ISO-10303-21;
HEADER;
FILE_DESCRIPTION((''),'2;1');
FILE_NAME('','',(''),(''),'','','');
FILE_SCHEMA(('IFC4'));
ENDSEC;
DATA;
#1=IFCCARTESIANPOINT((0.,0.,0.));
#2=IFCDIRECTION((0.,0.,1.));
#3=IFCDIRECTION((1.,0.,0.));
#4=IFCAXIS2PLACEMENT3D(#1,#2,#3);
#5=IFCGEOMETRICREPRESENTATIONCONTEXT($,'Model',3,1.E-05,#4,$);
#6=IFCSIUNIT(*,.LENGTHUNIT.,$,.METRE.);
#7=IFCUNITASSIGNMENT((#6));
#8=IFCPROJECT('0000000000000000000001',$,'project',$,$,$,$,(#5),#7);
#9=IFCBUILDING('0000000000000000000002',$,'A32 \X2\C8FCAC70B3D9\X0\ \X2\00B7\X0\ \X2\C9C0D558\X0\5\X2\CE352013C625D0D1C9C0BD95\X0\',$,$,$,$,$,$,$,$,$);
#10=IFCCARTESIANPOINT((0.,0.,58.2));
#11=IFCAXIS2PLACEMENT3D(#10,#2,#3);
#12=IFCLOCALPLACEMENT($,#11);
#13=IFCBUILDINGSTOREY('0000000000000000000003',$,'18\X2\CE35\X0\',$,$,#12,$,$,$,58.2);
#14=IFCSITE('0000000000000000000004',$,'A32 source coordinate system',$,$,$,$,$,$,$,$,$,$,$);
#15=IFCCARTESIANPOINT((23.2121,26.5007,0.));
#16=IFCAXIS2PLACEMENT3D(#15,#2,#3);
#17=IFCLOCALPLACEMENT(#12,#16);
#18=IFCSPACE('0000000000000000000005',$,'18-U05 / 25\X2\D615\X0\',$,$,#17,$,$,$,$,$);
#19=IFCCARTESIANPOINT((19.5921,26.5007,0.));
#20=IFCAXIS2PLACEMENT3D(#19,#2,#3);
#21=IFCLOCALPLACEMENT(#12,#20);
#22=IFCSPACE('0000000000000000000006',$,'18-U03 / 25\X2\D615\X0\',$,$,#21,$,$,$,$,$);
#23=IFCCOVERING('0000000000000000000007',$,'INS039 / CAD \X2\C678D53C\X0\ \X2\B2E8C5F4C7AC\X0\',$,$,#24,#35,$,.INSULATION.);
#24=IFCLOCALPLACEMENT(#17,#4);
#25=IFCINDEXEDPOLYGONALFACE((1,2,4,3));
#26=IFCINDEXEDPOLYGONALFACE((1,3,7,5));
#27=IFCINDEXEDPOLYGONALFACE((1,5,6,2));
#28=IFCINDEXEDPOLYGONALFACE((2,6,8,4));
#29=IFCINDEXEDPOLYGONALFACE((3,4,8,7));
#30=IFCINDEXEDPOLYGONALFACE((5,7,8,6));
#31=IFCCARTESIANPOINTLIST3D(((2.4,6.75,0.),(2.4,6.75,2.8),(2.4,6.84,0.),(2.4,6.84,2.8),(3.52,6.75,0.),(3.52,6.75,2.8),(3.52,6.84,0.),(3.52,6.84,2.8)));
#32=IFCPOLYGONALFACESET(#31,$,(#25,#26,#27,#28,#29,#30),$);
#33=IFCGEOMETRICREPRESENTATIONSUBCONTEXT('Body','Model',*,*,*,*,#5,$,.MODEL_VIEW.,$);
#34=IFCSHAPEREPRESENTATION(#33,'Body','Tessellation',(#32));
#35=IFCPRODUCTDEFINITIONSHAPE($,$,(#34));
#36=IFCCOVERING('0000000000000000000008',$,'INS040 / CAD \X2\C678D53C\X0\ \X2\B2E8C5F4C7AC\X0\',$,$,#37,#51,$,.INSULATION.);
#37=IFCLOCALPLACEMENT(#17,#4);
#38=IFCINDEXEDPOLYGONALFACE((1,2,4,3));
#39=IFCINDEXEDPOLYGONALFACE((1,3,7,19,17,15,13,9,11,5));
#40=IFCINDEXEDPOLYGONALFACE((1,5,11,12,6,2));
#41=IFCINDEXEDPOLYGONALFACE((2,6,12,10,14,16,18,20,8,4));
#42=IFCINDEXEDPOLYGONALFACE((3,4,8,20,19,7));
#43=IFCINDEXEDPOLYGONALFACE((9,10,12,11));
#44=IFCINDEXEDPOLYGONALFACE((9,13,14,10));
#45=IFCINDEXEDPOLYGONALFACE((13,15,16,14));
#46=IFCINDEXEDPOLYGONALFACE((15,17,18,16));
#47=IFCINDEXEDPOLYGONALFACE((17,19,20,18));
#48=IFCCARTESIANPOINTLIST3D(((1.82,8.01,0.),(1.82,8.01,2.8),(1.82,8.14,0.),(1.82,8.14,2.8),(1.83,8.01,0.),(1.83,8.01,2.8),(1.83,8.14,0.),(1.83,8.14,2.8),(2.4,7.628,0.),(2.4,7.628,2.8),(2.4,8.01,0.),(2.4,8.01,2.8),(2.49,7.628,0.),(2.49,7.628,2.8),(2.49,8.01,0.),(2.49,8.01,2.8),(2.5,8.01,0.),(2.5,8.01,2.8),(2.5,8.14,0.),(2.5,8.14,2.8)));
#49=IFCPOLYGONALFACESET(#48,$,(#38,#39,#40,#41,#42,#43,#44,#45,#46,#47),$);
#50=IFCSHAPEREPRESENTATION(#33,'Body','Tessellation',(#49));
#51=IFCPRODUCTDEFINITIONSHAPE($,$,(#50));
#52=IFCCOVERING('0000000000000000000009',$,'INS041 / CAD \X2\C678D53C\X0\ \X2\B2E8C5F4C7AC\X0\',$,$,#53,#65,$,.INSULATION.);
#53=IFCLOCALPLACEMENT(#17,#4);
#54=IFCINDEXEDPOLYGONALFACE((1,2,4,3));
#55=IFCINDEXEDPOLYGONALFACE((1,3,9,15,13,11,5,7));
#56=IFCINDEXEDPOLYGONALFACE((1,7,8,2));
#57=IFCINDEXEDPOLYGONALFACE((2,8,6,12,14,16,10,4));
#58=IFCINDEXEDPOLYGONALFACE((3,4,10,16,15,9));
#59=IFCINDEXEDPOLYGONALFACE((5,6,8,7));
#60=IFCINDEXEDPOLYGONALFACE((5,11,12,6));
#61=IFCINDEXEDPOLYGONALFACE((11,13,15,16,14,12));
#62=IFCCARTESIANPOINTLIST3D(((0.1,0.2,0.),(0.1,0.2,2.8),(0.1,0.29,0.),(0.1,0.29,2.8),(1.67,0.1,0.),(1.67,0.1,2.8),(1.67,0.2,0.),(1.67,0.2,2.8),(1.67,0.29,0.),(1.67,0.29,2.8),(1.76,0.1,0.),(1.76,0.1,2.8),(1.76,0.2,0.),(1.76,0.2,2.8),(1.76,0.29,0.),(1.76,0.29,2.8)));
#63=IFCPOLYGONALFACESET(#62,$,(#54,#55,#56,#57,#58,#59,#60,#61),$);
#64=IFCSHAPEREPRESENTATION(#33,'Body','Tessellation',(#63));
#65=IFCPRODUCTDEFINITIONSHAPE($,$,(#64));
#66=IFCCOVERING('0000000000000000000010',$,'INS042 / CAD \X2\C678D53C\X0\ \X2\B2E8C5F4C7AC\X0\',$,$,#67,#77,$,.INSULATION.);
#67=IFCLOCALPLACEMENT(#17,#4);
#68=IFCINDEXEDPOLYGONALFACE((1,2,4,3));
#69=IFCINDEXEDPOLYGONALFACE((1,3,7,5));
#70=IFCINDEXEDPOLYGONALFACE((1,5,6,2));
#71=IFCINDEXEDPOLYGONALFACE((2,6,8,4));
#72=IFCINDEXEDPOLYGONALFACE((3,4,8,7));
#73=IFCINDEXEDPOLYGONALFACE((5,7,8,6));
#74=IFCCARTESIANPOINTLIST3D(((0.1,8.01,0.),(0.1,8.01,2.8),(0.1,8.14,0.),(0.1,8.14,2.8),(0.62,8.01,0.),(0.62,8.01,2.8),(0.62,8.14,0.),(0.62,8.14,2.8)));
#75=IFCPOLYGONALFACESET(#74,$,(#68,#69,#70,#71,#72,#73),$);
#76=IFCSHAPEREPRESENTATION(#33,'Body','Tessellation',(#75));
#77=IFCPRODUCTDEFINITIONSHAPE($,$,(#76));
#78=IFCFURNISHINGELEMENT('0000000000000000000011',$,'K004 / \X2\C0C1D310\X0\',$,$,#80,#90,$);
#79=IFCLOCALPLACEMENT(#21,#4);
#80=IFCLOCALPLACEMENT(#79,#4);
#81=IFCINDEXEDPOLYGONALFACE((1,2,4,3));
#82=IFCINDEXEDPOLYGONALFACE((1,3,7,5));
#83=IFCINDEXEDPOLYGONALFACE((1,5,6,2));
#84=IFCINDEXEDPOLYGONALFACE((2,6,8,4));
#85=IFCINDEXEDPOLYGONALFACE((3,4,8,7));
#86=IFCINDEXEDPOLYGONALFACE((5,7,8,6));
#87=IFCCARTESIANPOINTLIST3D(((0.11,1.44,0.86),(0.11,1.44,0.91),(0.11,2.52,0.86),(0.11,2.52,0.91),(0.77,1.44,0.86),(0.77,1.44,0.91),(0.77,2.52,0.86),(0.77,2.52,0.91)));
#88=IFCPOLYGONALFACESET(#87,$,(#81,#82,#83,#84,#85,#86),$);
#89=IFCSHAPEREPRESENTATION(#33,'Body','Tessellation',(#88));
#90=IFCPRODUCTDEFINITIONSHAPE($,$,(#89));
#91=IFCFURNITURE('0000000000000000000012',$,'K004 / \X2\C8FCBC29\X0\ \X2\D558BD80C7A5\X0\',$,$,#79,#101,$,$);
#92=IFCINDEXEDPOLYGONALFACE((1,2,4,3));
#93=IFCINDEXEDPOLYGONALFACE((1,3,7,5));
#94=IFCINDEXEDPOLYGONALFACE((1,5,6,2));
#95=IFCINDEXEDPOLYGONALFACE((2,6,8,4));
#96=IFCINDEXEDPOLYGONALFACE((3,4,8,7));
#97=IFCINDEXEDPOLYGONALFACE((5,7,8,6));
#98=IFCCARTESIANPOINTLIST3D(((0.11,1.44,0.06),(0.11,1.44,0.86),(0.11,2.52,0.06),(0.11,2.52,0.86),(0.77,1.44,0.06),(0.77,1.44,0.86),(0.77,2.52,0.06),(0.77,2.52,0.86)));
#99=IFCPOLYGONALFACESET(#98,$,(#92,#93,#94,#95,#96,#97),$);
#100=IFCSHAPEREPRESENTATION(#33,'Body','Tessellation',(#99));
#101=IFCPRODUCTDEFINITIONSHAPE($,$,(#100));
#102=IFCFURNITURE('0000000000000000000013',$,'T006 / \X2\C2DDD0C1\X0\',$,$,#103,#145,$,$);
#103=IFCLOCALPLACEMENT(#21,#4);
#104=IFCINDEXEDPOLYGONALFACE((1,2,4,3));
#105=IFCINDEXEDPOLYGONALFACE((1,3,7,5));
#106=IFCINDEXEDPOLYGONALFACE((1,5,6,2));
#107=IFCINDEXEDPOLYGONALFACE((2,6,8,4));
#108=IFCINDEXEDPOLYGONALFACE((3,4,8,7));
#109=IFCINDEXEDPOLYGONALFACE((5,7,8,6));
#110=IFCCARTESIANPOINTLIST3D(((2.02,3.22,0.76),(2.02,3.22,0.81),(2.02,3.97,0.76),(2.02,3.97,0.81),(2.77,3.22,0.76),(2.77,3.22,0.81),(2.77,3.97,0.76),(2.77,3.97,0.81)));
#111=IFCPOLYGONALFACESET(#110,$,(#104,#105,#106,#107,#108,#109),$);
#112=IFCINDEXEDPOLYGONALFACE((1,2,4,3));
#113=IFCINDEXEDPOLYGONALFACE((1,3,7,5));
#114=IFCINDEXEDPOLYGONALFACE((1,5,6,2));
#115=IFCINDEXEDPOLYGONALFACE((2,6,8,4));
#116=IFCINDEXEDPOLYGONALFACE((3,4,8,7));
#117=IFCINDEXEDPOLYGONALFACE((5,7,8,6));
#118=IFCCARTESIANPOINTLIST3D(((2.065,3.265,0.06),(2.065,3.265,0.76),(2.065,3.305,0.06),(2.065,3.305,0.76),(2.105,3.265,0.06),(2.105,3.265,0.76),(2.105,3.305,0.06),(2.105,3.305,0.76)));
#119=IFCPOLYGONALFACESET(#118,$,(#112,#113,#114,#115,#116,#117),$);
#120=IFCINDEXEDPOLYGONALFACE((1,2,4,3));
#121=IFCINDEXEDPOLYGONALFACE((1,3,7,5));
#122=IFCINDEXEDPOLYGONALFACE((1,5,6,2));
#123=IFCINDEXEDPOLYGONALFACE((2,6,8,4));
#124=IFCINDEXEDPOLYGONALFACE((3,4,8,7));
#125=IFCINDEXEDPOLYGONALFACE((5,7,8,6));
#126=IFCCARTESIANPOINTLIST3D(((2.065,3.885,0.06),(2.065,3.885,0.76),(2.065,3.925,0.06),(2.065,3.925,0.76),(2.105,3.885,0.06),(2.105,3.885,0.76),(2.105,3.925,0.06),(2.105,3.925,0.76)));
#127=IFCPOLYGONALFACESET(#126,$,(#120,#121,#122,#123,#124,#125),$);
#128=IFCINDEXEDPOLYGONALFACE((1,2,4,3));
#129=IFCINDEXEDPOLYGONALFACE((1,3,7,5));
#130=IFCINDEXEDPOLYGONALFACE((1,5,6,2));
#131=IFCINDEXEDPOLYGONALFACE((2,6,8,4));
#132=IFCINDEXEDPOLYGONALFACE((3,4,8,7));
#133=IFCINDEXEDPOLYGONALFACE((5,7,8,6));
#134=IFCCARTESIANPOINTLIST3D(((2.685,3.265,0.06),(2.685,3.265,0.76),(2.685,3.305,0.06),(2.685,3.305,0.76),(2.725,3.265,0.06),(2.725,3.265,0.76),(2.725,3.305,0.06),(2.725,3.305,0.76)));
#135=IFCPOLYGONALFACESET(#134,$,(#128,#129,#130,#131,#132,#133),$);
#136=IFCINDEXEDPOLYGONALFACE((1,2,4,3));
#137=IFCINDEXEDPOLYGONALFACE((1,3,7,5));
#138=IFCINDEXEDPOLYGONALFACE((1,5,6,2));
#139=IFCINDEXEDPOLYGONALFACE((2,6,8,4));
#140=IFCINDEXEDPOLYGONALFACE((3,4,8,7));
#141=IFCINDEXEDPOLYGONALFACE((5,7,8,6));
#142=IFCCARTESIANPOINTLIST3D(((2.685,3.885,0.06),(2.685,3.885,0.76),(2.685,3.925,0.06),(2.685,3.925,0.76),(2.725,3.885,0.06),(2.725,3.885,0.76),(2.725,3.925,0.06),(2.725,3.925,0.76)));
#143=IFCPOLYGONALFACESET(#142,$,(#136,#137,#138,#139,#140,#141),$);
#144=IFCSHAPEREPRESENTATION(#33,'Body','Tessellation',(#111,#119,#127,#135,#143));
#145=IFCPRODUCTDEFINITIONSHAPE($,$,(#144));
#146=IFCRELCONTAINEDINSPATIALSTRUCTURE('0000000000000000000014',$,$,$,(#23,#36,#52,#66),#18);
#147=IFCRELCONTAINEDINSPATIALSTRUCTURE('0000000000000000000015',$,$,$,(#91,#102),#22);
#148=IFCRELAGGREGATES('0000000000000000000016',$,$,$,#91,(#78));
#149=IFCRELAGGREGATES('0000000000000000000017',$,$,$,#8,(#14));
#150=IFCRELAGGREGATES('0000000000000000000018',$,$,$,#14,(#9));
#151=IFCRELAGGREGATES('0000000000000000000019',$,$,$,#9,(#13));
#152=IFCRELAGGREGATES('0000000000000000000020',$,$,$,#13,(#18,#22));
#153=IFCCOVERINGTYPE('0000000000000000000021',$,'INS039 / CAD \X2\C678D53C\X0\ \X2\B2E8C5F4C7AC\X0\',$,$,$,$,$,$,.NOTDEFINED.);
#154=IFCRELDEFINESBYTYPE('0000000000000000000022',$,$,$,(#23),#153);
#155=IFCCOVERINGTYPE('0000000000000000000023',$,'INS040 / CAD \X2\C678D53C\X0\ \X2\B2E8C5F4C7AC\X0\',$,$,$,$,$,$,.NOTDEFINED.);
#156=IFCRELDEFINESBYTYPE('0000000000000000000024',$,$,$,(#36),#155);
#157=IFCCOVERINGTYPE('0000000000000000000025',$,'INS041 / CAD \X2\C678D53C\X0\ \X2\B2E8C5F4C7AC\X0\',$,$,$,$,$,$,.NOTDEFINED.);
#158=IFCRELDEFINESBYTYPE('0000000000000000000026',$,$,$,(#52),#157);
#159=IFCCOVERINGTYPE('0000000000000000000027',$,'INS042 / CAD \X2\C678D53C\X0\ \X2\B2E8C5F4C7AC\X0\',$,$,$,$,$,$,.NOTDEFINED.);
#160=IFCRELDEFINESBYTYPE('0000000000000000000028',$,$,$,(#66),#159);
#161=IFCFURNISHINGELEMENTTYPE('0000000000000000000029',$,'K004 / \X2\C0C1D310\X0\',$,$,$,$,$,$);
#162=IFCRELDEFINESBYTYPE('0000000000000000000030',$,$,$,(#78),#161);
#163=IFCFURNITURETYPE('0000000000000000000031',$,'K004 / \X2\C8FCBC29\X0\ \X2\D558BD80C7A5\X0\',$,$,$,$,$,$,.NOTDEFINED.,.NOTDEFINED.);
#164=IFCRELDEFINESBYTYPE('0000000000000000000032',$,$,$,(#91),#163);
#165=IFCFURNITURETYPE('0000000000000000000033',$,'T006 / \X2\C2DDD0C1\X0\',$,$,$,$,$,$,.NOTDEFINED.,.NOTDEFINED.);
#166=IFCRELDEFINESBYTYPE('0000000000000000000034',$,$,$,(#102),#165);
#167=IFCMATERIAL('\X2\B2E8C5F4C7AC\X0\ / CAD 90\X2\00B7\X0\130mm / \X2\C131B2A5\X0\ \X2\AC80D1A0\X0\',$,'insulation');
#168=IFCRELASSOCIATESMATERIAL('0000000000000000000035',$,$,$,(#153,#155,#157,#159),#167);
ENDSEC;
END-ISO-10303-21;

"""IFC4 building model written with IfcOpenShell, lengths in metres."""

from ifc_helpers import new_model, si_unit, frame, origin, origin_with_axes, place, context, subcontext, project, spatial, polyline, outline, extrude, source, transform, mapped, material, type_object, type_shapes, element, aggregate, save


model = new_model("IFC4")

# Units and contexts
model_context = context("Model", 3, precision=1e-05, world=origin_with_axes())
body_context = subcontext(model_context, "Body", "Model", "MODEL_VIEW")
ifc_project = project(units=[si_unit("LENGTHUNIT", "METRE")], contexts=[model_context])

# Site, building, storey, space
storey_placement = place(None, frame((0.0, 0.0, 58.2), z_axis=(0.0, 0.0, 1.0), x_axis=(1.0, 0.0, 0.0)))
space_1_placement = place(storey_placement, frame((23.2121, 26.5007, 0.0), z_axis=(0.0, 0.0, 1.0), x_axis=(1.0, 0.0, 0.0)))
site = spatial("IfcSite", under=ifc_project, Name="A32 source coordinate system")
building = spatial("IfcBuilding", under=site, Name="A32 주거동 · 지하5층–옥탑지붕")
storey = spatial("IfcBuildingStorey", under=building, at=storey_placement, Name="18층", Elevation=58.2)
space_1 = spatial("IfcSpace", under=storey, at=space_1_placement, Name="18-U05 / 25형")

# Shared definitions
space_2_placement = place(storey_placement, frame((19.5921, 26.5007, 0.0), z_axis=(0.0, 0.0, 1.0), x_axis=(1.0, 0.0, 0.0)))
space_2 = spatial("IfcSpace", under=storey, at=space_2_placement, Name="18-U03 / 25형")

# Coverings
ifc_material = material(Name="단열재 / CAD 90·130mm / 성능 검토", Category="insulation")
covering_type_1 = type_object("IfcCoveringType", Name="INS039 / CAD 외피 단열재", PredefinedType="NOTDEFINED", material=ifc_material)
shared_shape_1 = source(origin(), body_context, "Body", "SweptSolid", [
    extrude(outline(polyline([(2.4, 6.75), (2.4, 6.84), (3.52, 6.84), (3.52, 6.75), (2.4, 6.75)])), origin(), (0.0, 0.0, 1.0), 2.8),
])
type_shapes(covering_type_1, [shared_shape_1])
covering_1_placement = place(space_1_placement, origin_with_axes())
element("IfcCovering", 1, at=covering_1_placement, inside=space_1, type_object=covering_type_1, Name="INS039 / CAD 외피 단열재", PredefinedType="INSULATION", context=body_context, shape_type="MappedRepresentation", body=[
    mapped(shared_shape_1, transform((0.0, 0.0, 0.0), scale=1.0)),
])
covering_type_2 = type_object("IfcCoveringType", Name="INS040 / CAD 외피 단열재", PredefinedType="NOTDEFINED", material=ifc_material)
shared_shape_2 = source(origin(), body_context, "Body", "SweptSolid", [
    extrude(outline(polyline([(2.4, 7.628), (2.4, 8.01), (1.83, 8.01), (1.82, 8.01), (1.82, 8.14), (1.83, 8.14), (2.5, 8.14), (2.5, 8.01), (2.49, 8.01), (2.49, 7.628), (2.4, 7.628)])), origin(), (0.0, 0.0, 1.0), 2.8),
])
type_shapes(covering_type_2, [shared_shape_2])
covering_2_placement = place(space_1_placement, origin_with_axes())
element("IfcCovering", 2, at=covering_2_placement, inside=space_1, type_object=covering_type_2, Name="INS040 / CAD 외피 단열재", PredefinedType="INSULATION", context=body_context, shape_type="MappedRepresentation", body=[
    mapped(shared_shape_2, transform((0.0, 0.0, 0.0), scale=1.0)),
])
covering_type_3 = type_object("IfcCoveringType", Name="INS041 / CAD 외피 단열재", PredefinedType="NOTDEFINED", material=ifc_material)
shared_shape_3 = source(origin(), body_context, "Body", "SweptSolid", [
    extrude(outline(polyline([(1.67, 0.2), (0.1, 0.2), (0.1, 0.29), (1.67, 0.29), (1.76, 0.29), (1.76, 0.2), (1.76, 0.1), (1.67, 0.1), (1.67, 0.2)])), origin(), (0.0, 0.0, 1.0), 2.8),
])
type_shapes(covering_type_3, [shared_shape_3])
covering_3_placement = place(space_1_placement, origin_with_axes())
element("IfcCovering", 3, at=covering_3_placement, inside=space_1, type_object=covering_type_3, Name="INS041 / CAD 외피 단열재", PredefinedType="INSULATION", context=body_context, shape_type="MappedRepresentation", body=[
    mapped(shared_shape_3, transform((0.0, 0.0, 0.0), scale=1.0)),
])
covering_type_4 = type_object("IfcCoveringType", Name="INS042 / CAD 외피 단열재", PredefinedType="NOTDEFINED", material=ifc_material)
shared_shape_4 = source(origin(), body_context, "Body", "SweptSolid", [
    extrude(outline(polyline([(0.62, 8.14), (0.62, 8.01), (0.1, 8.01), (0.1, 8.14), (0.62, 8.14)])), origin(), (0.0, 0.0, 1.0), 2.8),
])
type_shapes(covering_type_4, [shared_shape_4])
covering_4_placement = place(space_1_placement, origin_with_axes())
element("IfcCovering", 4, at=covering_4_placement, inside=space_1, type_object=covering_type_4, Name="INS042 / CAD 외피 단열재", PredefinedType="INSULATION", context=body_context, shape_type="MappedRepresentation", body=[
    mapped(shared_shape_4, transform((0.0, 0.0, 0.0), scale=1.0)),
])

# Furnishing element
furnishing_element_type_1 = type_object("IfcFurnishingElementType", Name="K004 / 상판")
shared_shape_5 = source(origin(), body_context, "Body", "SweptSolid", [
    extrude(outline(polyline([(0.77, 2.52), (0.77, 1.44), (0.11, 1.44), (0.11, 2.52), (0.77, 2.52)])), frame((0.0, 0.0, 0.86)), (0.0, 0.0, 1.0), 0.05),
])
type_shapes(furnishing_element_type_1, [shared_shape_5])
furniture_1_placement = place(space_2_placement, origin_with_axes())
furnishing_1_placement = place(furniture_1_placement, origin_with_axes())
furnishing_1 = element("IfcFurnishingElement", 5, at=furnishing_1_placement, type_object=furnishing_element_type_1, Name="K004 / 상판", context=body_context, shape_type="MappedRepresentation", body=[
    mapped(shared_shape_5, transform((0.0, 0.0, 0.0), scale=1.0)),
])

# Furniture
furniture_type_1 = type_object("IfcFurnitureType", Name="K004 / 주방 하부장", AssemblyPlace="NOTDEFINED", PredefinedType="NOTDEFINED")
shared_shape_6 = source(origin(), body_context, "Body", "SweptSolid", [
    extrude(outline(polyline([(0.11, 2.52), (0.77, 2.52), (0.77, 1.44), (0.11, 1.44), (0.11, 2.52)])), frame((0.0, 0.0, 0.06)), (0.0, 0.0, 1.0), 0.8),
])
type_shapes(furniture_type_1, [shared_shape_6])
furniture_1 = element("IfcFurniture", 6, at=furniture_1_placement, inside=space_2, type_object=furniture_type_1, Name="K004 / 주방 하부장", context=body_context, shape_type="MappedRepresentation", body=[
    mapped(shared_shape_6, transform((0.0, 0.0, 0.0), scale=1.0)),
])
aggregate(furniture_1, [furnishing_1])
furniture_type_2 = type_object("IfcFurnitureType", Name="T006 / 식탁", AssemblyPlace="NOTDEFINED", PredefinedType="NOTDEFINED")
shared_shape_7 = source(origin(), body_context, "Body", "SweptSolid", [
    extrude(outline(polyline([(2.77, 3.22), (2.02, 3.22), (2.02, 3.97), (2.77, 3.97), (2.77, 3.22)])), frame((0.0, 0.0, 0.76)), (0.0, 0.0, 1.0), 0.05),
    extrude(outline(polyline([(2.065, 3.265), (2.065, 3.305), (2.105, 3.305), (2.105, 3.265), (2.065, 3.265)])), frame((0.0, 0.0, 0.06)), (0.0, 0.0, 1.0), 0.7),
    extrude(outline(polyline([(2.065, 3.885), (2.065, 3.925), (2.105, 3.925), (2.105, 3.885), (2.065, 3.885)])), frame((0.0, 0.0, 0.06)), (0.0, 0.0, 1.0), 0.7),
    extrude(outline(polyline([(2.685, 3.265), (2.685, 3.305), (2.725, 3.305), (2.725, 3.265), (2.685, 3.265)])), frame((0.0, 0.0, 0.06)), (0.0, 0.0, 1.0), 0.7),
    extrude(outline(polyline([(2.685, 3.885), (2.685, 3.925), (2.725, 3.925), (2.725, 3.885), (2.685, 3.885)])), frame((0.0, 0.0, 0.06)), (0.0, 0.0, 1.0), 0.7),
])
type_shapes(furniture_type_2, [shared_shape_7])
furniture_2_placement = place(space_2_placement, origin_with_axes())
element("IfcFurniture", 7, at=furniture_2_placement, inside=space_2, type_object=furniture_type_2, Name="T006 / 식탁", context=body_context, shape_type="MappedRepresentation", body=[
    mapped(shared_shape_7, transform((0.0, 0.0, 0.0), scale=1.0)),
])

save(model, "model.ifc")
